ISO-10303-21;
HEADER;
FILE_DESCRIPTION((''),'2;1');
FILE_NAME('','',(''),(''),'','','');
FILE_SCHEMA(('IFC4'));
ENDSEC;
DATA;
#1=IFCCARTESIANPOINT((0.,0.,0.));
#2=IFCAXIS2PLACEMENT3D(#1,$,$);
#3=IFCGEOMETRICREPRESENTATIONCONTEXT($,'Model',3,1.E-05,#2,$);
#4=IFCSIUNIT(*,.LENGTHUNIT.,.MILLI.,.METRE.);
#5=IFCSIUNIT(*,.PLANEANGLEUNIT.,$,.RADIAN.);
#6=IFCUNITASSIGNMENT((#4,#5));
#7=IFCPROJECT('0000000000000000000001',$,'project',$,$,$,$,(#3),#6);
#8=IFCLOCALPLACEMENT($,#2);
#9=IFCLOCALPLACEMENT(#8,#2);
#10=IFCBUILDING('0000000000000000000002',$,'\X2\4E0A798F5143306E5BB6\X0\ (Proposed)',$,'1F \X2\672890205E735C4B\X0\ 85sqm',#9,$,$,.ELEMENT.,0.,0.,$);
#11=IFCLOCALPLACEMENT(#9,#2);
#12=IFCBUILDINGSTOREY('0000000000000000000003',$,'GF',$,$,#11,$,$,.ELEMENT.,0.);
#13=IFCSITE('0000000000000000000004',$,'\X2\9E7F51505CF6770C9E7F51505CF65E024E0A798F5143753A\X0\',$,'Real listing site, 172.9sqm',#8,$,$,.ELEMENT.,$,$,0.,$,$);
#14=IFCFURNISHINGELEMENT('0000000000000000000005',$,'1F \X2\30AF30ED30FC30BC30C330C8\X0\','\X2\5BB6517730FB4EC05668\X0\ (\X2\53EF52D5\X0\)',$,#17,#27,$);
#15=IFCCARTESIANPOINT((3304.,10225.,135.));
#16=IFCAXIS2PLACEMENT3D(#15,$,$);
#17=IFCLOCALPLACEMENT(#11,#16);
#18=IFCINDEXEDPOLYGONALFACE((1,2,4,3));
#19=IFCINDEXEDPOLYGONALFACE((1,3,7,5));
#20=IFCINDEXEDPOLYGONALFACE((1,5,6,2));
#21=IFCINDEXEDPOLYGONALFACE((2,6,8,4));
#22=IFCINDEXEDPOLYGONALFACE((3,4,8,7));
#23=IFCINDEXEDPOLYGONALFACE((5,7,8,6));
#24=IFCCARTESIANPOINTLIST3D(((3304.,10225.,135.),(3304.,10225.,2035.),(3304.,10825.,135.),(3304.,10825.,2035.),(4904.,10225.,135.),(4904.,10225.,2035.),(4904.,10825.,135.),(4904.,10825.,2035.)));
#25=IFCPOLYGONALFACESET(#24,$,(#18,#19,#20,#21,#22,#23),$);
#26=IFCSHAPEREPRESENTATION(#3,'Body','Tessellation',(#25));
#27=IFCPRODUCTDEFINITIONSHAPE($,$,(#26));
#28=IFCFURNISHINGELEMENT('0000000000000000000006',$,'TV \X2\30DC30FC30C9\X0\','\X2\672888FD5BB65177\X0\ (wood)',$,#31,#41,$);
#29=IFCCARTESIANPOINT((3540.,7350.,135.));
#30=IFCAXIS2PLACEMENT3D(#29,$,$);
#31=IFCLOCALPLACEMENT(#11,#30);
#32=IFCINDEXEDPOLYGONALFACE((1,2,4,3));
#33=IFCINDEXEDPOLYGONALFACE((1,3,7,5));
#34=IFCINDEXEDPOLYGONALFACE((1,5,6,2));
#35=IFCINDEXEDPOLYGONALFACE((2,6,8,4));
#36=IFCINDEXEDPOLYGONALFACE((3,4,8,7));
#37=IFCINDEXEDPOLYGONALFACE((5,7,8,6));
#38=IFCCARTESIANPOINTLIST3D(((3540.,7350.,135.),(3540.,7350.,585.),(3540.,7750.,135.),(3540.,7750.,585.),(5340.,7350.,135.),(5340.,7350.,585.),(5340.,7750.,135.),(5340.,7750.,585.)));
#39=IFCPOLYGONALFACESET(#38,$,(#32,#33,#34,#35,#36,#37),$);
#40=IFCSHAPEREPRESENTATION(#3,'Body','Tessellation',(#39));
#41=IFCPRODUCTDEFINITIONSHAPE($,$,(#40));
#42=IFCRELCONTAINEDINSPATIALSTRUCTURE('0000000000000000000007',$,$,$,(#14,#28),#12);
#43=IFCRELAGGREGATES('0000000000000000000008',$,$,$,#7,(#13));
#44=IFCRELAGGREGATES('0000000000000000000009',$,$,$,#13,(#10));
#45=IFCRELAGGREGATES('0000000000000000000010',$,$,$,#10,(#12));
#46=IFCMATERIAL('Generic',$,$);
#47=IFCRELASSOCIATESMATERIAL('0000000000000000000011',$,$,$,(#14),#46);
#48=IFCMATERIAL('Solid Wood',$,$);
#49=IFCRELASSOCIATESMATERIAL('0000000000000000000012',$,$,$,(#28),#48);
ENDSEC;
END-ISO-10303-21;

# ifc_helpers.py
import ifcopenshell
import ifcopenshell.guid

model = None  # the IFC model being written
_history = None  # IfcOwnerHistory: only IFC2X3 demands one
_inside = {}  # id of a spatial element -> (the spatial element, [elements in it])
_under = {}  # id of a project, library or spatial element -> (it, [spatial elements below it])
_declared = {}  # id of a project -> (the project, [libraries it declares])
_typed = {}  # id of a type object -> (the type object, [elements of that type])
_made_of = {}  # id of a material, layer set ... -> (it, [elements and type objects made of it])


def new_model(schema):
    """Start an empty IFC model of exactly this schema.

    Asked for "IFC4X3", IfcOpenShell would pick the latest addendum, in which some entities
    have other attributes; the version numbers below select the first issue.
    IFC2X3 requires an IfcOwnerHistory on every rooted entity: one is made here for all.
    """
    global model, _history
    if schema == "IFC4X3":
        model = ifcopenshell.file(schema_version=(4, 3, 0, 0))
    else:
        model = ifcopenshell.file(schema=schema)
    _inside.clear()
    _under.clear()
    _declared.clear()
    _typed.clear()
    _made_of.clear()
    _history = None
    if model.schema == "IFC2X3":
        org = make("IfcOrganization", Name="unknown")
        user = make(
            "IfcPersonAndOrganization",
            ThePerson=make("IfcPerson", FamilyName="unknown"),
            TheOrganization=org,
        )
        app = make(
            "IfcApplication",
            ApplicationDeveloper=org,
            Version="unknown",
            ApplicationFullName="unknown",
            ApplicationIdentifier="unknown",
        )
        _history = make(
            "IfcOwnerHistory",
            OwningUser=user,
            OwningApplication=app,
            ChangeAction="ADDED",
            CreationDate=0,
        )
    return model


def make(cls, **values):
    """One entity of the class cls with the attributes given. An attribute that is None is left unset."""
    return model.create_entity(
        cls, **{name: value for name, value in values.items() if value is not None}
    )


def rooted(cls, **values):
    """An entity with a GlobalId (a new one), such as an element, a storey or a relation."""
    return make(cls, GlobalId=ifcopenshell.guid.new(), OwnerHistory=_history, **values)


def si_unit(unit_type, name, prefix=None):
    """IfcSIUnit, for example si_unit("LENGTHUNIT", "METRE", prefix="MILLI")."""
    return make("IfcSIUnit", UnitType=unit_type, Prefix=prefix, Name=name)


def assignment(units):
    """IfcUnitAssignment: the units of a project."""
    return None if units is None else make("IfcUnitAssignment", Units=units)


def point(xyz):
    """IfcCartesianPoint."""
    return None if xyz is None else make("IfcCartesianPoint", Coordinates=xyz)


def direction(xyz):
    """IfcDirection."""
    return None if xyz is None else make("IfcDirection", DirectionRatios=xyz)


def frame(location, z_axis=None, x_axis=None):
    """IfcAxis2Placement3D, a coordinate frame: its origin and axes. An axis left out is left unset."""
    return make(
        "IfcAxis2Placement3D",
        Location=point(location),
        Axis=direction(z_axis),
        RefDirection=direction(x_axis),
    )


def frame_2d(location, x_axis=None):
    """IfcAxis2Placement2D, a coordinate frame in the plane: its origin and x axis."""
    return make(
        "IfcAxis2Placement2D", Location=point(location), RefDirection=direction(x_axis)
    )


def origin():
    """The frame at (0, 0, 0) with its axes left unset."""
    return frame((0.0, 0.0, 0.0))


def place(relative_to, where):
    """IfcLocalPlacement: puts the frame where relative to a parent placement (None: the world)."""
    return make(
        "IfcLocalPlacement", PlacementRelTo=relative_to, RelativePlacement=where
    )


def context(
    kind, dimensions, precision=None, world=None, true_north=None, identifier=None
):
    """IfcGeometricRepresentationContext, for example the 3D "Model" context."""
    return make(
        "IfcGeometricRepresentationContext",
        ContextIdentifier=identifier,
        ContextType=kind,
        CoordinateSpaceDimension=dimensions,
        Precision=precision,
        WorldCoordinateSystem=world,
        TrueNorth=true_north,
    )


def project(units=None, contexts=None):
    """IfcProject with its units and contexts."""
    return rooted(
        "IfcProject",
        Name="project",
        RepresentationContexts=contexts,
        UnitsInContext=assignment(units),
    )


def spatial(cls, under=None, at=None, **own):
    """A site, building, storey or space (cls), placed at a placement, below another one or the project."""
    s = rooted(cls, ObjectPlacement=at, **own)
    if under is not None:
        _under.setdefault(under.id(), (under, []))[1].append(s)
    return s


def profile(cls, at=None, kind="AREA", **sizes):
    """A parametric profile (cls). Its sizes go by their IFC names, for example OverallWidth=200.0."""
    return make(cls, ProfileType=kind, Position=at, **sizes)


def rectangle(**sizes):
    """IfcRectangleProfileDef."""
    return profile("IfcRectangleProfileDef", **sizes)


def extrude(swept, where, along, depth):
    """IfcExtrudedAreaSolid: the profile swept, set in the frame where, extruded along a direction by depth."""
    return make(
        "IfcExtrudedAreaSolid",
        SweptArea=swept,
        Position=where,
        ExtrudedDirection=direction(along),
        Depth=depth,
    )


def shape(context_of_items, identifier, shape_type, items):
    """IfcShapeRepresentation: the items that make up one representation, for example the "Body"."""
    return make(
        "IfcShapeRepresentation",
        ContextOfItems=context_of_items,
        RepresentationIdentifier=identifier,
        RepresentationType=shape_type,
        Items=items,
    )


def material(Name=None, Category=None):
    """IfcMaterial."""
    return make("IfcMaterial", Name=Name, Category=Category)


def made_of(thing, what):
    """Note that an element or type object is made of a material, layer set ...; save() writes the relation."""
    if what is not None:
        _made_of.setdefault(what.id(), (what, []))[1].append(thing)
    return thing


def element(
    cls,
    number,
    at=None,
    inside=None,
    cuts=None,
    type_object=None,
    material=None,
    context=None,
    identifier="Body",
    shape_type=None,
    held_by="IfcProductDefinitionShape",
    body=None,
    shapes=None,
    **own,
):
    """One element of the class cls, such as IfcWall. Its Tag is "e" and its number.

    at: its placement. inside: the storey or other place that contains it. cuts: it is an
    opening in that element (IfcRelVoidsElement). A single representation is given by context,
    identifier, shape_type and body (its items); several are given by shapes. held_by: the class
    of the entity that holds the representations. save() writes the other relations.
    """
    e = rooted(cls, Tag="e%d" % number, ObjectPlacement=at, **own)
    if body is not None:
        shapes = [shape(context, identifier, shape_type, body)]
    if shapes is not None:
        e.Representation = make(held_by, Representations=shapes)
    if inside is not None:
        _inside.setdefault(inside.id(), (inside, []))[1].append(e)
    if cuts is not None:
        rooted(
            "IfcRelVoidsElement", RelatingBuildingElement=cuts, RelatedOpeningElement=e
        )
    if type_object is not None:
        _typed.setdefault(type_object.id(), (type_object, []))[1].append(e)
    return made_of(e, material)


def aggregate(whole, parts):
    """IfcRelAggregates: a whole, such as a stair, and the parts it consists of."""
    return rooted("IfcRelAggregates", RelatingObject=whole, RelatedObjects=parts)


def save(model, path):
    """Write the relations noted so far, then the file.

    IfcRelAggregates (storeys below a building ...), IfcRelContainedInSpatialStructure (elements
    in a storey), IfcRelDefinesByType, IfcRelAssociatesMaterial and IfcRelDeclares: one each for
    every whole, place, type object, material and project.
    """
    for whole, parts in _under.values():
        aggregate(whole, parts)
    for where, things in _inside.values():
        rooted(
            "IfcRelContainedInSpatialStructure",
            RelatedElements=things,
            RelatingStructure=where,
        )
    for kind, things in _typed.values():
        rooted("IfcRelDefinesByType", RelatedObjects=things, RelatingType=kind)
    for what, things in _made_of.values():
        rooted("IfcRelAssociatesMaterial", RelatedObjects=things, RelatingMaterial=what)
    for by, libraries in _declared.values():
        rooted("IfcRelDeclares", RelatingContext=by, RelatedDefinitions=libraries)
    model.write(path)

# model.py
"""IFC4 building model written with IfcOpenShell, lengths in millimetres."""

from ifc_helpers import new_model, si_unit, frame, frame_2d, origin, place, context, project, spatial, rectangle, extrude, material, element, save


model = new_model("IFC4")

# Units and contexts
model_context = context("Model", 3, precision=1e-05, world=origin())
ifc_project = project(units=[si_unit("LENGTHUNIT", "METRE", prefix="MILLI"), si_unit("PLANEANGLEUNIT", "RADIAN")], contexts=[model_context])

# Site, building, storey
site_placement = place(None, origin())
site = spatial("IfcSite", under=ifc_project, at=site_placement, Name="鹿児島県鹿児島市上福元町", ObjectType="Real listing site, 172.9sqm", CompositionType="ELEMENT", RefElevation=0.0)
building_placement = place(site_placement, origin())
building = spatial("IfcBuilding", under=site, at=building_placement, Name="上福元の家 (Proposed)", ObjectType="1F 木造平屋 85sqm", CompositionType="ELEMENT", ElevationOfRefHeight=0.0, ElevationOfTerrain=0.0)
storey_placement = place(building_placement, origin())
storey = spatial("IfcBuildingStorey", under=building, at=storey_placement, Name="GF", CompositionType="ELEMENT", Elevation=0.0)

# Shared definitions
ifc_material_1 = material(Name="Solid Wood")

# Shared definitions
ifc_material_2 = material(Name="Generic")

# Furnishing elements
furnishing_1_placement = place(storey_placement, frame((3304.0, 10225.0, 135.0)))
element("IfcFurnishingElement", 1, at=furnishing_1_placement, inside=storey, material=ifc_material_2, Name="1F クローゼット", Description="家具・什器 (可動)", context=model_context, shape_type="SweptSolid", body=[
    extrude(rectangle(XDim=1600.0, YDim=600.0, at=frame_2d((800.0, 300.0))), frame((3304.0, 10225.0, 135.0)), (0.0, 0.0, 1.0), 1900.0),
])
furnishing_2_placement = place(storey_placement, frame((3540.0, 7350.0, 135.0)))
element("IfcFurnishingElement", 2, at=furnishing_2_placement, inside=storey, material=ifc_material_1, Name="TV ボード", Description="木製家具 (wood)", context=model_context, shape_type="SweptSolid", body=[
    extrude(rectangle(XDim=1800.0, YDim=400.0, at=frame_2d((900.0, 200.0))), frame((3540.0, 7350.0, 135.0)), (0.0, 0.0, 1.0), 450.0),
])

save(model, "model.ifc")
